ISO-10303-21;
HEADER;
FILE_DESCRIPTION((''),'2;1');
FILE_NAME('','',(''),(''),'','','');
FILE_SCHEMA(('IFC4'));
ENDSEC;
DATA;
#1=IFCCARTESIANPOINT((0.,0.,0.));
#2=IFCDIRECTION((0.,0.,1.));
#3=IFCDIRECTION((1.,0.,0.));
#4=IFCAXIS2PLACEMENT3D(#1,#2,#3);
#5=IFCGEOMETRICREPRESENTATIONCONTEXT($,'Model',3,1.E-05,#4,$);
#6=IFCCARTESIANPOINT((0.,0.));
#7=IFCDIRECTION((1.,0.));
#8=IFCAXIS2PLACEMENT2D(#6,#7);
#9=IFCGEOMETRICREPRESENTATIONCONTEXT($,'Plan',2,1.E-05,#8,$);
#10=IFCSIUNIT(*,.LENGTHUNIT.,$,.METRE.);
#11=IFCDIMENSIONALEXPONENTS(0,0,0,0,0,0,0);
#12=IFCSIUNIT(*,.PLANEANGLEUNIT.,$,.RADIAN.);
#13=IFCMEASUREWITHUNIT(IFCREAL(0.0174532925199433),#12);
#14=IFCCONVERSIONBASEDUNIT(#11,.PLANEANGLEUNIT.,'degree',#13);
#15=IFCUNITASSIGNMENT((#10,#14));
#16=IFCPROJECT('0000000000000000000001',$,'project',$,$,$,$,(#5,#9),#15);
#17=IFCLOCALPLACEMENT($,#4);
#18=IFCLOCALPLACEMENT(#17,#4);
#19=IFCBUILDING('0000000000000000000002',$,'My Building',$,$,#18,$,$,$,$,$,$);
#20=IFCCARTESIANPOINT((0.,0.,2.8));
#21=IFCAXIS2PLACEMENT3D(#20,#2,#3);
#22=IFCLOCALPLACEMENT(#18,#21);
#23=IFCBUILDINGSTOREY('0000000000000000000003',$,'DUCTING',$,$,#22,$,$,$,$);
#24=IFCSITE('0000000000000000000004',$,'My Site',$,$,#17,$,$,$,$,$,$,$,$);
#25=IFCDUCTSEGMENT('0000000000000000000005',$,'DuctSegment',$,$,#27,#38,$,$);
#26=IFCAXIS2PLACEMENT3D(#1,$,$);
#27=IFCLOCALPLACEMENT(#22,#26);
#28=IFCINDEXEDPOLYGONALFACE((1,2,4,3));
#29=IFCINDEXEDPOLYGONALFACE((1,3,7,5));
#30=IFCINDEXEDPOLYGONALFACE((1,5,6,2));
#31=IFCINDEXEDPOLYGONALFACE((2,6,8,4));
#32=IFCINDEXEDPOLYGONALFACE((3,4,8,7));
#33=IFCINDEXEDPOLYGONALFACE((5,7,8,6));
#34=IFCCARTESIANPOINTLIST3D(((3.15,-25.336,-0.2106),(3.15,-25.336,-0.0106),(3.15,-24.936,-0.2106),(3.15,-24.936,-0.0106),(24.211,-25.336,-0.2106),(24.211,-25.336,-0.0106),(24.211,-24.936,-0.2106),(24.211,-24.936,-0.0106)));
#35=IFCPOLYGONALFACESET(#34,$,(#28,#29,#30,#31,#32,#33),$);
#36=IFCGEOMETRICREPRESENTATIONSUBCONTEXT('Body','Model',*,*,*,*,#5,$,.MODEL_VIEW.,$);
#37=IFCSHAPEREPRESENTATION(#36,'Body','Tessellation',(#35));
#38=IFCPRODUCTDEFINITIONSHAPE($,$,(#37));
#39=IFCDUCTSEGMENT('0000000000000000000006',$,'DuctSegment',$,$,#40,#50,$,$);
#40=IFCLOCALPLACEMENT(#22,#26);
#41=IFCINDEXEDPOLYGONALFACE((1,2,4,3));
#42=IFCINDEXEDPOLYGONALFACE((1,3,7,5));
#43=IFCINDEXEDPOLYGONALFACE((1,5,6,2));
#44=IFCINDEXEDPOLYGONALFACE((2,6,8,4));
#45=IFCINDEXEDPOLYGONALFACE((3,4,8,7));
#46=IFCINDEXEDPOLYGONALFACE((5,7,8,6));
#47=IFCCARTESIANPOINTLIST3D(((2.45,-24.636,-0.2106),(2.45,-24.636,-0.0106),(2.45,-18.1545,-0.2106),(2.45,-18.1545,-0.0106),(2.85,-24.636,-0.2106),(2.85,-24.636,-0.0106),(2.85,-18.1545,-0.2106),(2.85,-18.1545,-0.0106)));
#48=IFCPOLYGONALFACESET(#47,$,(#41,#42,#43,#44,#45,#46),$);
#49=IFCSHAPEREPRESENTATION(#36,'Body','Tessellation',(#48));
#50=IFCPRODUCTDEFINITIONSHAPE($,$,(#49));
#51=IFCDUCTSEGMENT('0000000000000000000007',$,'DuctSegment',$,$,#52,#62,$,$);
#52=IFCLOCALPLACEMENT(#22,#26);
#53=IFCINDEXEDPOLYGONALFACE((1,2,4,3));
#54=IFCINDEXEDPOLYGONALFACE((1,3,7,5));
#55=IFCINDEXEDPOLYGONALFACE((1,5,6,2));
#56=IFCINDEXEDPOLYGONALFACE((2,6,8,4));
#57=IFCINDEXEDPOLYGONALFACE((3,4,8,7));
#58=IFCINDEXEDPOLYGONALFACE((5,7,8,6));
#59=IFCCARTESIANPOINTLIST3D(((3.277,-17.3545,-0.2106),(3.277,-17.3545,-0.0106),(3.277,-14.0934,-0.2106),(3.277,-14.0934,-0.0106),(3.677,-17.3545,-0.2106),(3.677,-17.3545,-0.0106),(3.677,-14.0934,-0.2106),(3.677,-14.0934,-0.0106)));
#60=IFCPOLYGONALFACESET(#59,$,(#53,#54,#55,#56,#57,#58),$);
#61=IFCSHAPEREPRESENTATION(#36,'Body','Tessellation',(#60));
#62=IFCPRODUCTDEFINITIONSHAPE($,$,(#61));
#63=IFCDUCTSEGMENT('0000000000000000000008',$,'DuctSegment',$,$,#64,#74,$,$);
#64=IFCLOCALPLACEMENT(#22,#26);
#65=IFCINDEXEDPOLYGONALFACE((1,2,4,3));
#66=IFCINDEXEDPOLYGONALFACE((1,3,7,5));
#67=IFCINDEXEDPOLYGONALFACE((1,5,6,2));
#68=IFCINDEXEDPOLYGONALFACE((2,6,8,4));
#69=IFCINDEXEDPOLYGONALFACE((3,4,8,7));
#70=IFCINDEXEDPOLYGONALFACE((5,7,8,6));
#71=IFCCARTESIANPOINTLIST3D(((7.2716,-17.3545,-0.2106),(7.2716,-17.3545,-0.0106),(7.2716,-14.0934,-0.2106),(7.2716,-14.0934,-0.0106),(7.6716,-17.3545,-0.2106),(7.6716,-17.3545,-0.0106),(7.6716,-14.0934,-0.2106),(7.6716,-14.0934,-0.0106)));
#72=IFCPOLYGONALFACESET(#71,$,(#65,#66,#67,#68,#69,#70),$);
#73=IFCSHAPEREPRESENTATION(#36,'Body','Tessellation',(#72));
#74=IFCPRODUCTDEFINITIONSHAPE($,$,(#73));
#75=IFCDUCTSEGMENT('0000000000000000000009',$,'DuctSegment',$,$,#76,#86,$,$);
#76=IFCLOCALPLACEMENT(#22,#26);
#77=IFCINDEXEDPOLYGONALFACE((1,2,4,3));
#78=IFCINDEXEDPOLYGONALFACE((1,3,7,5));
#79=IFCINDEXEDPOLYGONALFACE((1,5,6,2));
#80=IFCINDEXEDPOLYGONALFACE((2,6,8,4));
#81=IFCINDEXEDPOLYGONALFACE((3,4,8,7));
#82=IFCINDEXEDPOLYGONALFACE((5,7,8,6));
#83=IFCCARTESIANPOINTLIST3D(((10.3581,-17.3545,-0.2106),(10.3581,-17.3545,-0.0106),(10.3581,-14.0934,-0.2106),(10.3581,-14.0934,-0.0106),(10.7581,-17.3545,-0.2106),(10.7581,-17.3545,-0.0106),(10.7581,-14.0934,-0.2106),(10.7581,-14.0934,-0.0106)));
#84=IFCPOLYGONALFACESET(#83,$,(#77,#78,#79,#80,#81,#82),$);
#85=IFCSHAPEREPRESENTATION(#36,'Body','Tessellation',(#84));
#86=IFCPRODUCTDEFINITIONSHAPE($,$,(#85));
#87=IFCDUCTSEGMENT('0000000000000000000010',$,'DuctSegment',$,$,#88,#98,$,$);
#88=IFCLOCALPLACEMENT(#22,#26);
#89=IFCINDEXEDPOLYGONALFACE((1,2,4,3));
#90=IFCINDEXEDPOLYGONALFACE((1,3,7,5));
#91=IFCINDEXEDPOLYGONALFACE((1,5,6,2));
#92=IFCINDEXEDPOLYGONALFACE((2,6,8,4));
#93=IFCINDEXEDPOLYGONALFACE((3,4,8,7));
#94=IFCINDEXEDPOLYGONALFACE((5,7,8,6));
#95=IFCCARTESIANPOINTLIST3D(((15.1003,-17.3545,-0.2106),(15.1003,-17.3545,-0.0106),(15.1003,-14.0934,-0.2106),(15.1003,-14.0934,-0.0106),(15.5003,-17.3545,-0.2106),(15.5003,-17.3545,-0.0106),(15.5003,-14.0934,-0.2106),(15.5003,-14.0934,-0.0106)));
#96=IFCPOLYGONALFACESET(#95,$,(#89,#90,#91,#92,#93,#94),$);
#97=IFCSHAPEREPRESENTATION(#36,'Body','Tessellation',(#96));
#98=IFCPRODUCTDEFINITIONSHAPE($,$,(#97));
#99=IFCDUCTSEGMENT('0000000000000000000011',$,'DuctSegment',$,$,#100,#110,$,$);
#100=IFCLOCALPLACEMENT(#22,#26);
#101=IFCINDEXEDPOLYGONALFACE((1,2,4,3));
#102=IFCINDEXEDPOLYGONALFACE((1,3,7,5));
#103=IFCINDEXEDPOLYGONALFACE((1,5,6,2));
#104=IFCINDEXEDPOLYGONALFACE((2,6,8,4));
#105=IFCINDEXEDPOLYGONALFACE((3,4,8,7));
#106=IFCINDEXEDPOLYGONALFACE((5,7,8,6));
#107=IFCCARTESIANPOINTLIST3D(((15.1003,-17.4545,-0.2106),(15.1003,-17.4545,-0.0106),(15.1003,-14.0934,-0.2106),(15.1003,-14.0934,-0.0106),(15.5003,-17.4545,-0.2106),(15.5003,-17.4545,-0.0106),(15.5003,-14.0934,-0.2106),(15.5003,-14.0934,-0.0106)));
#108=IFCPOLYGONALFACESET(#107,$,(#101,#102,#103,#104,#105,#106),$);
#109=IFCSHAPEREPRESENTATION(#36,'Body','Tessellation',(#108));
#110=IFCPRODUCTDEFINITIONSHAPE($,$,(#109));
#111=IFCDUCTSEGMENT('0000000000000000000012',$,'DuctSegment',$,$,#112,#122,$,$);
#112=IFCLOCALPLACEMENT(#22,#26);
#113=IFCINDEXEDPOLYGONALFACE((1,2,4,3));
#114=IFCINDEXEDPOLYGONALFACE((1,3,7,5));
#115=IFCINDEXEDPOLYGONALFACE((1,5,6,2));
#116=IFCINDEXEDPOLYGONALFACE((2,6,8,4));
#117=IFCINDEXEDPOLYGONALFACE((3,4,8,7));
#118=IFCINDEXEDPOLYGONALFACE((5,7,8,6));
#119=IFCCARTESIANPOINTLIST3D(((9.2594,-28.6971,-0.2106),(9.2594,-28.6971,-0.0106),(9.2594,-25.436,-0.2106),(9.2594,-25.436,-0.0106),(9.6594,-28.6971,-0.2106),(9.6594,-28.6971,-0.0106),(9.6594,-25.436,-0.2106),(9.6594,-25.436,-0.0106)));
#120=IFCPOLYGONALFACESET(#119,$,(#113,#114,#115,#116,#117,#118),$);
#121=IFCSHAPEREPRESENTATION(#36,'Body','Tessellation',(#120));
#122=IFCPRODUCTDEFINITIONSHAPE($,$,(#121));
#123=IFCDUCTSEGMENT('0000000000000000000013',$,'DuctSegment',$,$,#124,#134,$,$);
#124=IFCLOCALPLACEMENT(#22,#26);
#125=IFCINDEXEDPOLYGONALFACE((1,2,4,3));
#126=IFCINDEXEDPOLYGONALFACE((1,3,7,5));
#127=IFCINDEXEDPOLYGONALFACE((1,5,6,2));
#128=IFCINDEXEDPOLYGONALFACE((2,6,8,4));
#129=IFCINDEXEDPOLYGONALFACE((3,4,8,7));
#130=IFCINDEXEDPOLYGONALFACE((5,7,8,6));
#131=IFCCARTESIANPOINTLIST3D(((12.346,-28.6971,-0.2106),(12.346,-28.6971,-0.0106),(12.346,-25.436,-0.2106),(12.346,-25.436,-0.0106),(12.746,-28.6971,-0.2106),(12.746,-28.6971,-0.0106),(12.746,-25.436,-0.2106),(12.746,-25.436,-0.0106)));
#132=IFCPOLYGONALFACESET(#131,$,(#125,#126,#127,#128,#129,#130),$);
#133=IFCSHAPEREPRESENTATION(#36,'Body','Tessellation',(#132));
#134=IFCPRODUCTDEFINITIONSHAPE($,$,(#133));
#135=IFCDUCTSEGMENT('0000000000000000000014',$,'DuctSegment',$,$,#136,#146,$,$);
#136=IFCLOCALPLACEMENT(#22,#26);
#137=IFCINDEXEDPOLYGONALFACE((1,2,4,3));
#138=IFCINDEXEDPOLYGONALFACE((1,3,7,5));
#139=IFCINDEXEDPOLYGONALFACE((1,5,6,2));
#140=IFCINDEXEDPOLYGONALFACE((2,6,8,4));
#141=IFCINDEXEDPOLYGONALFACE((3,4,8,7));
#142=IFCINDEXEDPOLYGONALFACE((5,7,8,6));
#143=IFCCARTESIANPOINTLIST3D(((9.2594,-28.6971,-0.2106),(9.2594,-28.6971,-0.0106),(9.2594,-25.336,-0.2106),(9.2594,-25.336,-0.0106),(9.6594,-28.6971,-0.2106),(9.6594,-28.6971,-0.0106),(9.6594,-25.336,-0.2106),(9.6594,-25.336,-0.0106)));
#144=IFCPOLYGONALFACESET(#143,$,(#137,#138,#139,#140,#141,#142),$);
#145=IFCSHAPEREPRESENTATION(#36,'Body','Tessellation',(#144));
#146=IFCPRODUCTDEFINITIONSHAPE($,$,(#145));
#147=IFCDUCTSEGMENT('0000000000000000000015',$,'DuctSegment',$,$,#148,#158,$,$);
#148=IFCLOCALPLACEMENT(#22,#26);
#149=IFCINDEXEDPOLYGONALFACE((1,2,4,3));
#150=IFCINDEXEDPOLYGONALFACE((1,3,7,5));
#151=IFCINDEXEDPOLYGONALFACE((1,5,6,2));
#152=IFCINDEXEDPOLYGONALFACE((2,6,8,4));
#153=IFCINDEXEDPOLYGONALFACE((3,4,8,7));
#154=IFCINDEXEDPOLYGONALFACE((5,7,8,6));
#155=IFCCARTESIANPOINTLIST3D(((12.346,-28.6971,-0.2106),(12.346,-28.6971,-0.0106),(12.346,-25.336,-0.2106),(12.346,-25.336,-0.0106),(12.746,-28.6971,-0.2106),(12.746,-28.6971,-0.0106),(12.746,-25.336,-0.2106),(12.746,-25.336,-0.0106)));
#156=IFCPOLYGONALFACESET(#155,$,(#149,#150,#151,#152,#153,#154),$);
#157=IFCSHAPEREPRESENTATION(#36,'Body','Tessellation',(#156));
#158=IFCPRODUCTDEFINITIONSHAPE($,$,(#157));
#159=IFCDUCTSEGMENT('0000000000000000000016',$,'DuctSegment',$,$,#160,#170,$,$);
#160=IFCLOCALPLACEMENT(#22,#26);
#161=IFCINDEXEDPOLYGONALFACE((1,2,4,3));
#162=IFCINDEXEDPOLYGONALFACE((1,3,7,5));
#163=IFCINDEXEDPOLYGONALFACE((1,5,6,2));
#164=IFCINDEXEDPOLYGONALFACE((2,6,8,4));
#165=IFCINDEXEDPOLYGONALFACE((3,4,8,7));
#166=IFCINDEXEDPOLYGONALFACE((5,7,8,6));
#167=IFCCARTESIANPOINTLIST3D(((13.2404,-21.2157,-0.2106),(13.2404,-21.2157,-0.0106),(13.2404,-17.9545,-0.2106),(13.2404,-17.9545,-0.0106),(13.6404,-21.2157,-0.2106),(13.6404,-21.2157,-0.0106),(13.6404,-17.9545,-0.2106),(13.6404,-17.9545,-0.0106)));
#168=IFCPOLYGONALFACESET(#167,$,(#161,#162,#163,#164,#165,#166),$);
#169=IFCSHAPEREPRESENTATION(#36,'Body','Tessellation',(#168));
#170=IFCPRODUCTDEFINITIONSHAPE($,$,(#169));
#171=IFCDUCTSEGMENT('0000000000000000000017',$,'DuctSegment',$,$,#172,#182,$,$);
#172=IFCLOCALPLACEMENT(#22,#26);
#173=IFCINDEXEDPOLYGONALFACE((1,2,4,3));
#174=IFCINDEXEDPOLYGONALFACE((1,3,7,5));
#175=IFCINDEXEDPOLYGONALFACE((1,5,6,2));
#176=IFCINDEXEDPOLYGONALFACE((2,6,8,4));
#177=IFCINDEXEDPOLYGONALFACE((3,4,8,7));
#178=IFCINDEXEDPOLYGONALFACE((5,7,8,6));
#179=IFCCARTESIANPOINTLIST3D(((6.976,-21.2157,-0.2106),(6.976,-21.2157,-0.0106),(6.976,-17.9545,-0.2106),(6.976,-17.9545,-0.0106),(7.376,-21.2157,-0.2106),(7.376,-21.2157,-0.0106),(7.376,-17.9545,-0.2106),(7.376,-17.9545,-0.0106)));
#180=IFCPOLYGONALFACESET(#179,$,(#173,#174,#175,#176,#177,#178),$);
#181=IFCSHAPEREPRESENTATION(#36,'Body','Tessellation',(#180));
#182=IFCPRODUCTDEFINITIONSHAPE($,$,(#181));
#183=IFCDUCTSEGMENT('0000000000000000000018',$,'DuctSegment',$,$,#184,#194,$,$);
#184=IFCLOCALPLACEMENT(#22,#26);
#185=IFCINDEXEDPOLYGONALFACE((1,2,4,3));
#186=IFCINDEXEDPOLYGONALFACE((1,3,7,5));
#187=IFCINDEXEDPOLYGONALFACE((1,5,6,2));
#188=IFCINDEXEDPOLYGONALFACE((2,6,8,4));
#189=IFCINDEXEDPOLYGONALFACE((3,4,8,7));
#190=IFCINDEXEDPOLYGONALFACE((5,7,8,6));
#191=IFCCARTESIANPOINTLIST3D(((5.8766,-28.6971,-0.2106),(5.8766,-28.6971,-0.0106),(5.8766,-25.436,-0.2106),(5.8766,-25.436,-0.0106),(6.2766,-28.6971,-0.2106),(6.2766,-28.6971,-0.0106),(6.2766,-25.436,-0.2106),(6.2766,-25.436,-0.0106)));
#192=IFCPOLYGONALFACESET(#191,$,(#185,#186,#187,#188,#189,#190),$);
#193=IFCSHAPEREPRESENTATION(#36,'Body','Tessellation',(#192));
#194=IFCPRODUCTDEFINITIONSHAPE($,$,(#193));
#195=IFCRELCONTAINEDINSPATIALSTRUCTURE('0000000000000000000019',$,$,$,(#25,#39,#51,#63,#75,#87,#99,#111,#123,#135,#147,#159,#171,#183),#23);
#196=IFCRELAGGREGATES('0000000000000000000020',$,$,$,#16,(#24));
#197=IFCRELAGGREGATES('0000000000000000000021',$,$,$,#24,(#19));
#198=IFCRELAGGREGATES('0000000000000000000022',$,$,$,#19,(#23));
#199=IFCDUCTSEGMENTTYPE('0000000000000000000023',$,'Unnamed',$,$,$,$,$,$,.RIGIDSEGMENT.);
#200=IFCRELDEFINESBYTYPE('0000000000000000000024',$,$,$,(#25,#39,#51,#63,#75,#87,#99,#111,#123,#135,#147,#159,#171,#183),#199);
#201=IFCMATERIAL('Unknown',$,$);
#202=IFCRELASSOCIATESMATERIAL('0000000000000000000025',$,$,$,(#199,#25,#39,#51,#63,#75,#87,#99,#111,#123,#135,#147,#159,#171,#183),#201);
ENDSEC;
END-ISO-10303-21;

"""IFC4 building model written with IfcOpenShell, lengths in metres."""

from ifc_helpers import new_model, entity, si_unit, converted_unit, frame, origin_with_axes, origin_2d_with_axis, place, context, subcontext, project, spatial, rectangle, extrude, material, material_profile, profile_set, profile_usage, type_object, element, save


model = new_model("IFC4")

# Units and contexts
model_context = context("Model", 3, precision=1e-05, world=origin_with_axes())
plan_context = context("Plan", 2, precision=1e-05, world=origin_2d_with_axis())
body_context = subcontext(model_context, "Body", "Model", "MODEL_VIEW")
ifc_project = project(units=[si_unit("LENGTHUNIT", "METRE"), converted_unit("PLANEANGLEUNIT", "degree", entity("IfcReal", 0.0174532925199433), si_unit("PLANEANGLEUNIT", "RADIAN"), dimensions=[0, 0, 0, 0, 0, 0, 0])], contexts=[model_context, plan_context])

# Site, building, storey
site_placement = place(None, origin_with_axes())
site = spatial("IfcSite", under=ifc_project, at=site_placement, Name="My Site")
building_placement = place(site_placement, origin_with_axes())
building = spatial("IfcBuilding", under=site, at=building_placement, Name="My Building")
storey_placement = place(building_placement, frame((0.0, 0.0, 2.8), z_axis=(0.0, 0.0, 1.0), x_axis=(1.0, 0.0, 0.0)))
storey = spatial("IfcBuildingStorey", under=building, at=storey_placement, Name="DUCTING")

# Duct segments
ifc_material = material(Name="Unknown")
ifc_material_profile_1 = material_profile(ifc_material, rectangle(XDim=0.4, YDim=0.2))
ifc_profile_set_1 = profile_set([ifc_material_profile_1])
ifc_profile_usage_1 = profile_usage(ifc_profile_set_1, cardinal=5)
duct_segment_type = type_object("IfcDuctSegmentType", Name="Unnamed", PredefinedType="RIGIDSEGMENT", material=ifc_profile_set_1)
duct_segment_1_placement = place(storey_placement, frame((3.15, -25.136, -0.1106), z_axis=(1.0, 0.0, 0.0), x_axis=(0.0, 1.0, 0.0)))
element("IfcDuctSegment", 1, at=duct_segment_1_placement, inside=storey, type_object=duct_segment_type, material=ifc_profile_usage_1, Name="DuctSegment", context=body_context, shape_type="SweptSolid", body=[
    extrude(rectangle(XDim=0.4, YDim=0.2), origin_with_axes(), (0.0, 0.0, 1.0), 21.061),
])
ifc_profile_usage_2 = profile_usage(ifc_profile_set_1, cardinal=5)
duct_segment_2_placement = place(storey_placement, frame((2.65, -18.1545, -0.1106), z_axis=(-0.000004, -1.0, -0.000001), x_axis=(1.0, -0.000004, 0.0)))
element("IfcDuctSegment", 2, at=duct_segment_2_placement, inside=storey, type_object=duct_segment_type, material=ifc_profile_usage_2, Name="DuctSegment", context=body_context, shape_type="SweptSolid", body=[
    extrude(rectangle(XDim=0.4, YDim=0.2), origin_with_axes(), (0.0, 0.0, 1.0), 6.4815),
])
ifc_profile_usage_3 = profile_usage(ifc_profile_set_1, cardinal=5)
duct_segment_3_placement = place(storey_placement, frame((3.477, -17.3545, -0.1106), z_axis=(0.0, 1.0, 0.0), x_axis=(-1.0, 0.0, 0.0)))
element("IfcDuctSegment", 3, at=duct_segment_3_placement, inside=storey, type_object=duct_segment_type, material=ifc_profile_usage_3, Name="DuctSegment", context=body_context, shape_type="SweptSolid", body=[
    extrude(rectangle(XDim=0.4, YDim=0.2), origin_with_axes(), (0.0, 0.0, 1.0), 3.2611),
])
ifc_profile_usage_4 = profile_usage(ifc_profile_set_1, cardinal=5)
duct_segment_4_placement = place(storey_placement, frame((7.4716, -17.3545, -0.1106), z_axis=(0.0, 1.0, 0.0), x_axis=(-1.0, 0.0, 0.0)))
element("IfcDuctSegment", 4, at=duct_segment_4_placement, inside=storey, type_object=duct_segment_type, material=ifc_profile_usage_4, Name="DuctSegment", context=body_context, shape_type="SweptSolid", body=[
    extrude(rectangle(XDim=0.4, YDim=0.2), origin_with_axes(), (0.0, 0.0, 1.0), 3.2611),
])
ifc_profile_usage_5 = profile_usage(ifc_profile_set_1, cardinal=5)
duct_segment_5_placement = place(storey_placement, frame((10.5581, -17.3545, -0.1106), z_axis=(0.0, 1.0, 0.0), x_axis=(-1.0, 0.0, 0.0)))
element("IfcDuctSegment", 5, at=duct_segment_5_placement, inside=storey, type_object=duct_segment_type, material=ifc_profile_usage_5, Name="DuctSegment", context=body_context, shape_type="SweptSolid", body=[
    extrude(rectangle(XDim=0.4, YDim=0.2), origin_with_axes(), (0.0, 0.0, 1.0), 3.2611),
])
ifc_profile_usage_6 = profile_usage(ifc_profile_set_1, cardinal=5)
duct_segment_6_placement = place(storey_placement, frame((15.3003, -17.3545, -0.1106), z_axis=(0.0, 1.0, 0.0), x_axis=(-1.0, 0.0, 0.0)))
element("IfcDuctSegment", 6, at=duct_segment_6_placement, inside=storey, type_object=duct_segment_type, material=ifc_profile_usage_6, Name="DuctSegment", context=body_context, shape_type="SweptSolid", body=[
    extrude(rectangle(XDim=0.4, YDim=0.2), origin_with_axes(), (0.0, 0.0, 1.0), 3.2611),
])
ifc_profile_usage_7 = profile_usage(ifc_profile_set_1, cardinal=5)
duct_segment_7_placement = place(storey_placement, frame((15.3003, -17.4545, -0.1106), z_axis=(0.0, 1.0, 0.0), x_axis=(-1.0, 0.0, 0.0)))
element("IfcDuctSegment", 7, at=duct_segment_7_placement, inside=storey, type_object=duct_segment_type, material=ifc_profile_usage_7, Name="DuctSegment", context=body_context, shape_type="SweptSolid", body=[
    extrude(rectangle(XDim=0.4, YDim=0.2), origin_with_axes(), (0.0, 0.0, 1.0), 3.3611),
])
ifc_profile_usage_8 = profile_usage(ifc_profile_set_1, cardinal=5)
duct_segment_8_placement = place(storey_placement, frame((9.4594, -28.6971, -0.1106), z_axis=(0.0, 1.0, 0.0), x_axis=(-1.0, 0.0, 0.0)))
element("IfcDuctSegment", 8, at=duct_segment_8_placement, inside=storey, type_object=duct_segment_type, material=ifc_profile_usage_8, Name="DuctSegment", context=body_context, shape_type="SweptSolid", body=[
    extrude(rectangle(XDim=0.4, YDim=0.2), origin_with_axes(), (0.0, 0.0, 1.0), 3.2611),
])
ifc_profile_usage_9 = profile_usage(ifc_profile_set_1, cardinal=5)
duct_segment_9_placement = place(storey_placement, frame((12.546, -28.6971, -0.1106), z_axis=(0.0, 1.0, 0.0), x_axis=(-1.0, 0.0, 0.0)))
element("IfcDuctSegment", 9, at=duct_segment_9_placement, inside=storey, type_object=duct_segment_type, material=ifc_profile_usage_9, Name="DuctSegment", context=body_context, shape_type="SweptSolid", body=[
    extrude(rectangle(XDim=0.4, YDim=0.2), origin_with_axes(), (0.0, 0.0, 1.0), 3.2611),
])
ifc_profile_usage_10 = profile_usage(ifc_profile_set_1, cardinal=5)
duct_segment_10_placement = place(storey_placement, frame((9.4594, -28.6971, -0.1106), z_axis=(0.0, 1.0, 0.0), x_axis=(-1.0, 0.0, 0.0)))
element("IfcDuctSegment", 10, at=duct_segment_10_placement, inside=storey, type_object=duct_segment_type, material=ifc_profile_usage_10, Name="DuctSegment", context=body_context, shape_type="SweptSolid", body=[
    extrude(rectangle(XDim=0.4, YDim=0.2), origin_with_axes(), (0.0, 0.0, 1.0), 3.3611),
])
ifc_profile_usage_11 = profile_usage(ifc_profile_set_1, cardinal=5)
duct_segment_11_placement = place(storey_placement, frame((12.546, -28.6971, -0.1106), z_axis=(0.0, 1.0, 0.0), x_axis=(-1.0, 0.0, 0.0)))
element("IfcDuctSegment", 11, at=duct_segment_11_placement, inside=storey, type_object=duct_segment_type, material=ifc_profile_usage_11, Name="DuctSegment", context=body_context, shape_type="SweptSolid", body=[
    extrude(rectangle(XDim=0.4, YDim=0.2), origin_with_axes(), (0.0, 0.0, 1.0), 3.3611),
])
ifc_profile_usage_12 = profile_usage(ifc_profile_set_1, cardinal=5)
duct_segment_12_placement = place(storey_placement, frame((13.4404, -21.2157, -0.1106), z_axis=(0.0, 1.0, 0.0), x_axis=(-1.0, 0.0, 0.0)))
element("IfcDuctSegment", 12, at=duct_segment_12_placement, inside=storey, type_object=duct_segment_type, material=ifc_profile_usage_12, Name="DuctSegment", context=body_context, shape_type="SweptSolid", body=[
    extrude(rectangle(XDim=0.4, YDim=0.2), origin_with_axes(), (0.0, 0.0, 1.0), 3.2611),
])
ifc_profile_usage_13 = profile_usage(ifc_profile_set_1, cardinal=5)
duct_segment_13_placement = place(storey_placement, frame((7.176, -21.2157, -0.1106), z_axis=(0.0, 1.0, 0.0), x_axis=(-1.0, 0.0, 0.0)))
element("IfcDuctSegment", 13, at=duct_segment_13_placement, inside=storey, type_object=duct_segment_type, material=ifc_profile_usage_13, Name="DuctSegment", context=body_context, shape_type="SweptSolid", body=[
    extrude(rectangle(XDim=0.4, YDim=0.2), origin_with_axes(), (0.0, 0.0, 1.0), 3.2611),
])
ifc_profile_usage_14 = profile_usage(ifc_profile_set_1, cardinal=5)
duct_segment_14_placement = place(storey_placement, frame((6.0766, -28.6971, -0.1106), z_axis=(0.0, 1.0, 0.0), x_axis=(-1.0, 0.0, 0.0)))
element("IfcDuctSegment", 14, at=duct_segment_14_placement, inside=storey, type_object=duct_segment_type, material=ifc_profile_usage_14, Name="DuctSegment", context=body_context, shape_type="SweptSolid", body=[
    extrude(rectangle(XDim=0.4, YDim=0.2), origin_with_axes(), (0.0, 0.0, 1.0), 3.2611),
])

save(model, "model.ifc")
